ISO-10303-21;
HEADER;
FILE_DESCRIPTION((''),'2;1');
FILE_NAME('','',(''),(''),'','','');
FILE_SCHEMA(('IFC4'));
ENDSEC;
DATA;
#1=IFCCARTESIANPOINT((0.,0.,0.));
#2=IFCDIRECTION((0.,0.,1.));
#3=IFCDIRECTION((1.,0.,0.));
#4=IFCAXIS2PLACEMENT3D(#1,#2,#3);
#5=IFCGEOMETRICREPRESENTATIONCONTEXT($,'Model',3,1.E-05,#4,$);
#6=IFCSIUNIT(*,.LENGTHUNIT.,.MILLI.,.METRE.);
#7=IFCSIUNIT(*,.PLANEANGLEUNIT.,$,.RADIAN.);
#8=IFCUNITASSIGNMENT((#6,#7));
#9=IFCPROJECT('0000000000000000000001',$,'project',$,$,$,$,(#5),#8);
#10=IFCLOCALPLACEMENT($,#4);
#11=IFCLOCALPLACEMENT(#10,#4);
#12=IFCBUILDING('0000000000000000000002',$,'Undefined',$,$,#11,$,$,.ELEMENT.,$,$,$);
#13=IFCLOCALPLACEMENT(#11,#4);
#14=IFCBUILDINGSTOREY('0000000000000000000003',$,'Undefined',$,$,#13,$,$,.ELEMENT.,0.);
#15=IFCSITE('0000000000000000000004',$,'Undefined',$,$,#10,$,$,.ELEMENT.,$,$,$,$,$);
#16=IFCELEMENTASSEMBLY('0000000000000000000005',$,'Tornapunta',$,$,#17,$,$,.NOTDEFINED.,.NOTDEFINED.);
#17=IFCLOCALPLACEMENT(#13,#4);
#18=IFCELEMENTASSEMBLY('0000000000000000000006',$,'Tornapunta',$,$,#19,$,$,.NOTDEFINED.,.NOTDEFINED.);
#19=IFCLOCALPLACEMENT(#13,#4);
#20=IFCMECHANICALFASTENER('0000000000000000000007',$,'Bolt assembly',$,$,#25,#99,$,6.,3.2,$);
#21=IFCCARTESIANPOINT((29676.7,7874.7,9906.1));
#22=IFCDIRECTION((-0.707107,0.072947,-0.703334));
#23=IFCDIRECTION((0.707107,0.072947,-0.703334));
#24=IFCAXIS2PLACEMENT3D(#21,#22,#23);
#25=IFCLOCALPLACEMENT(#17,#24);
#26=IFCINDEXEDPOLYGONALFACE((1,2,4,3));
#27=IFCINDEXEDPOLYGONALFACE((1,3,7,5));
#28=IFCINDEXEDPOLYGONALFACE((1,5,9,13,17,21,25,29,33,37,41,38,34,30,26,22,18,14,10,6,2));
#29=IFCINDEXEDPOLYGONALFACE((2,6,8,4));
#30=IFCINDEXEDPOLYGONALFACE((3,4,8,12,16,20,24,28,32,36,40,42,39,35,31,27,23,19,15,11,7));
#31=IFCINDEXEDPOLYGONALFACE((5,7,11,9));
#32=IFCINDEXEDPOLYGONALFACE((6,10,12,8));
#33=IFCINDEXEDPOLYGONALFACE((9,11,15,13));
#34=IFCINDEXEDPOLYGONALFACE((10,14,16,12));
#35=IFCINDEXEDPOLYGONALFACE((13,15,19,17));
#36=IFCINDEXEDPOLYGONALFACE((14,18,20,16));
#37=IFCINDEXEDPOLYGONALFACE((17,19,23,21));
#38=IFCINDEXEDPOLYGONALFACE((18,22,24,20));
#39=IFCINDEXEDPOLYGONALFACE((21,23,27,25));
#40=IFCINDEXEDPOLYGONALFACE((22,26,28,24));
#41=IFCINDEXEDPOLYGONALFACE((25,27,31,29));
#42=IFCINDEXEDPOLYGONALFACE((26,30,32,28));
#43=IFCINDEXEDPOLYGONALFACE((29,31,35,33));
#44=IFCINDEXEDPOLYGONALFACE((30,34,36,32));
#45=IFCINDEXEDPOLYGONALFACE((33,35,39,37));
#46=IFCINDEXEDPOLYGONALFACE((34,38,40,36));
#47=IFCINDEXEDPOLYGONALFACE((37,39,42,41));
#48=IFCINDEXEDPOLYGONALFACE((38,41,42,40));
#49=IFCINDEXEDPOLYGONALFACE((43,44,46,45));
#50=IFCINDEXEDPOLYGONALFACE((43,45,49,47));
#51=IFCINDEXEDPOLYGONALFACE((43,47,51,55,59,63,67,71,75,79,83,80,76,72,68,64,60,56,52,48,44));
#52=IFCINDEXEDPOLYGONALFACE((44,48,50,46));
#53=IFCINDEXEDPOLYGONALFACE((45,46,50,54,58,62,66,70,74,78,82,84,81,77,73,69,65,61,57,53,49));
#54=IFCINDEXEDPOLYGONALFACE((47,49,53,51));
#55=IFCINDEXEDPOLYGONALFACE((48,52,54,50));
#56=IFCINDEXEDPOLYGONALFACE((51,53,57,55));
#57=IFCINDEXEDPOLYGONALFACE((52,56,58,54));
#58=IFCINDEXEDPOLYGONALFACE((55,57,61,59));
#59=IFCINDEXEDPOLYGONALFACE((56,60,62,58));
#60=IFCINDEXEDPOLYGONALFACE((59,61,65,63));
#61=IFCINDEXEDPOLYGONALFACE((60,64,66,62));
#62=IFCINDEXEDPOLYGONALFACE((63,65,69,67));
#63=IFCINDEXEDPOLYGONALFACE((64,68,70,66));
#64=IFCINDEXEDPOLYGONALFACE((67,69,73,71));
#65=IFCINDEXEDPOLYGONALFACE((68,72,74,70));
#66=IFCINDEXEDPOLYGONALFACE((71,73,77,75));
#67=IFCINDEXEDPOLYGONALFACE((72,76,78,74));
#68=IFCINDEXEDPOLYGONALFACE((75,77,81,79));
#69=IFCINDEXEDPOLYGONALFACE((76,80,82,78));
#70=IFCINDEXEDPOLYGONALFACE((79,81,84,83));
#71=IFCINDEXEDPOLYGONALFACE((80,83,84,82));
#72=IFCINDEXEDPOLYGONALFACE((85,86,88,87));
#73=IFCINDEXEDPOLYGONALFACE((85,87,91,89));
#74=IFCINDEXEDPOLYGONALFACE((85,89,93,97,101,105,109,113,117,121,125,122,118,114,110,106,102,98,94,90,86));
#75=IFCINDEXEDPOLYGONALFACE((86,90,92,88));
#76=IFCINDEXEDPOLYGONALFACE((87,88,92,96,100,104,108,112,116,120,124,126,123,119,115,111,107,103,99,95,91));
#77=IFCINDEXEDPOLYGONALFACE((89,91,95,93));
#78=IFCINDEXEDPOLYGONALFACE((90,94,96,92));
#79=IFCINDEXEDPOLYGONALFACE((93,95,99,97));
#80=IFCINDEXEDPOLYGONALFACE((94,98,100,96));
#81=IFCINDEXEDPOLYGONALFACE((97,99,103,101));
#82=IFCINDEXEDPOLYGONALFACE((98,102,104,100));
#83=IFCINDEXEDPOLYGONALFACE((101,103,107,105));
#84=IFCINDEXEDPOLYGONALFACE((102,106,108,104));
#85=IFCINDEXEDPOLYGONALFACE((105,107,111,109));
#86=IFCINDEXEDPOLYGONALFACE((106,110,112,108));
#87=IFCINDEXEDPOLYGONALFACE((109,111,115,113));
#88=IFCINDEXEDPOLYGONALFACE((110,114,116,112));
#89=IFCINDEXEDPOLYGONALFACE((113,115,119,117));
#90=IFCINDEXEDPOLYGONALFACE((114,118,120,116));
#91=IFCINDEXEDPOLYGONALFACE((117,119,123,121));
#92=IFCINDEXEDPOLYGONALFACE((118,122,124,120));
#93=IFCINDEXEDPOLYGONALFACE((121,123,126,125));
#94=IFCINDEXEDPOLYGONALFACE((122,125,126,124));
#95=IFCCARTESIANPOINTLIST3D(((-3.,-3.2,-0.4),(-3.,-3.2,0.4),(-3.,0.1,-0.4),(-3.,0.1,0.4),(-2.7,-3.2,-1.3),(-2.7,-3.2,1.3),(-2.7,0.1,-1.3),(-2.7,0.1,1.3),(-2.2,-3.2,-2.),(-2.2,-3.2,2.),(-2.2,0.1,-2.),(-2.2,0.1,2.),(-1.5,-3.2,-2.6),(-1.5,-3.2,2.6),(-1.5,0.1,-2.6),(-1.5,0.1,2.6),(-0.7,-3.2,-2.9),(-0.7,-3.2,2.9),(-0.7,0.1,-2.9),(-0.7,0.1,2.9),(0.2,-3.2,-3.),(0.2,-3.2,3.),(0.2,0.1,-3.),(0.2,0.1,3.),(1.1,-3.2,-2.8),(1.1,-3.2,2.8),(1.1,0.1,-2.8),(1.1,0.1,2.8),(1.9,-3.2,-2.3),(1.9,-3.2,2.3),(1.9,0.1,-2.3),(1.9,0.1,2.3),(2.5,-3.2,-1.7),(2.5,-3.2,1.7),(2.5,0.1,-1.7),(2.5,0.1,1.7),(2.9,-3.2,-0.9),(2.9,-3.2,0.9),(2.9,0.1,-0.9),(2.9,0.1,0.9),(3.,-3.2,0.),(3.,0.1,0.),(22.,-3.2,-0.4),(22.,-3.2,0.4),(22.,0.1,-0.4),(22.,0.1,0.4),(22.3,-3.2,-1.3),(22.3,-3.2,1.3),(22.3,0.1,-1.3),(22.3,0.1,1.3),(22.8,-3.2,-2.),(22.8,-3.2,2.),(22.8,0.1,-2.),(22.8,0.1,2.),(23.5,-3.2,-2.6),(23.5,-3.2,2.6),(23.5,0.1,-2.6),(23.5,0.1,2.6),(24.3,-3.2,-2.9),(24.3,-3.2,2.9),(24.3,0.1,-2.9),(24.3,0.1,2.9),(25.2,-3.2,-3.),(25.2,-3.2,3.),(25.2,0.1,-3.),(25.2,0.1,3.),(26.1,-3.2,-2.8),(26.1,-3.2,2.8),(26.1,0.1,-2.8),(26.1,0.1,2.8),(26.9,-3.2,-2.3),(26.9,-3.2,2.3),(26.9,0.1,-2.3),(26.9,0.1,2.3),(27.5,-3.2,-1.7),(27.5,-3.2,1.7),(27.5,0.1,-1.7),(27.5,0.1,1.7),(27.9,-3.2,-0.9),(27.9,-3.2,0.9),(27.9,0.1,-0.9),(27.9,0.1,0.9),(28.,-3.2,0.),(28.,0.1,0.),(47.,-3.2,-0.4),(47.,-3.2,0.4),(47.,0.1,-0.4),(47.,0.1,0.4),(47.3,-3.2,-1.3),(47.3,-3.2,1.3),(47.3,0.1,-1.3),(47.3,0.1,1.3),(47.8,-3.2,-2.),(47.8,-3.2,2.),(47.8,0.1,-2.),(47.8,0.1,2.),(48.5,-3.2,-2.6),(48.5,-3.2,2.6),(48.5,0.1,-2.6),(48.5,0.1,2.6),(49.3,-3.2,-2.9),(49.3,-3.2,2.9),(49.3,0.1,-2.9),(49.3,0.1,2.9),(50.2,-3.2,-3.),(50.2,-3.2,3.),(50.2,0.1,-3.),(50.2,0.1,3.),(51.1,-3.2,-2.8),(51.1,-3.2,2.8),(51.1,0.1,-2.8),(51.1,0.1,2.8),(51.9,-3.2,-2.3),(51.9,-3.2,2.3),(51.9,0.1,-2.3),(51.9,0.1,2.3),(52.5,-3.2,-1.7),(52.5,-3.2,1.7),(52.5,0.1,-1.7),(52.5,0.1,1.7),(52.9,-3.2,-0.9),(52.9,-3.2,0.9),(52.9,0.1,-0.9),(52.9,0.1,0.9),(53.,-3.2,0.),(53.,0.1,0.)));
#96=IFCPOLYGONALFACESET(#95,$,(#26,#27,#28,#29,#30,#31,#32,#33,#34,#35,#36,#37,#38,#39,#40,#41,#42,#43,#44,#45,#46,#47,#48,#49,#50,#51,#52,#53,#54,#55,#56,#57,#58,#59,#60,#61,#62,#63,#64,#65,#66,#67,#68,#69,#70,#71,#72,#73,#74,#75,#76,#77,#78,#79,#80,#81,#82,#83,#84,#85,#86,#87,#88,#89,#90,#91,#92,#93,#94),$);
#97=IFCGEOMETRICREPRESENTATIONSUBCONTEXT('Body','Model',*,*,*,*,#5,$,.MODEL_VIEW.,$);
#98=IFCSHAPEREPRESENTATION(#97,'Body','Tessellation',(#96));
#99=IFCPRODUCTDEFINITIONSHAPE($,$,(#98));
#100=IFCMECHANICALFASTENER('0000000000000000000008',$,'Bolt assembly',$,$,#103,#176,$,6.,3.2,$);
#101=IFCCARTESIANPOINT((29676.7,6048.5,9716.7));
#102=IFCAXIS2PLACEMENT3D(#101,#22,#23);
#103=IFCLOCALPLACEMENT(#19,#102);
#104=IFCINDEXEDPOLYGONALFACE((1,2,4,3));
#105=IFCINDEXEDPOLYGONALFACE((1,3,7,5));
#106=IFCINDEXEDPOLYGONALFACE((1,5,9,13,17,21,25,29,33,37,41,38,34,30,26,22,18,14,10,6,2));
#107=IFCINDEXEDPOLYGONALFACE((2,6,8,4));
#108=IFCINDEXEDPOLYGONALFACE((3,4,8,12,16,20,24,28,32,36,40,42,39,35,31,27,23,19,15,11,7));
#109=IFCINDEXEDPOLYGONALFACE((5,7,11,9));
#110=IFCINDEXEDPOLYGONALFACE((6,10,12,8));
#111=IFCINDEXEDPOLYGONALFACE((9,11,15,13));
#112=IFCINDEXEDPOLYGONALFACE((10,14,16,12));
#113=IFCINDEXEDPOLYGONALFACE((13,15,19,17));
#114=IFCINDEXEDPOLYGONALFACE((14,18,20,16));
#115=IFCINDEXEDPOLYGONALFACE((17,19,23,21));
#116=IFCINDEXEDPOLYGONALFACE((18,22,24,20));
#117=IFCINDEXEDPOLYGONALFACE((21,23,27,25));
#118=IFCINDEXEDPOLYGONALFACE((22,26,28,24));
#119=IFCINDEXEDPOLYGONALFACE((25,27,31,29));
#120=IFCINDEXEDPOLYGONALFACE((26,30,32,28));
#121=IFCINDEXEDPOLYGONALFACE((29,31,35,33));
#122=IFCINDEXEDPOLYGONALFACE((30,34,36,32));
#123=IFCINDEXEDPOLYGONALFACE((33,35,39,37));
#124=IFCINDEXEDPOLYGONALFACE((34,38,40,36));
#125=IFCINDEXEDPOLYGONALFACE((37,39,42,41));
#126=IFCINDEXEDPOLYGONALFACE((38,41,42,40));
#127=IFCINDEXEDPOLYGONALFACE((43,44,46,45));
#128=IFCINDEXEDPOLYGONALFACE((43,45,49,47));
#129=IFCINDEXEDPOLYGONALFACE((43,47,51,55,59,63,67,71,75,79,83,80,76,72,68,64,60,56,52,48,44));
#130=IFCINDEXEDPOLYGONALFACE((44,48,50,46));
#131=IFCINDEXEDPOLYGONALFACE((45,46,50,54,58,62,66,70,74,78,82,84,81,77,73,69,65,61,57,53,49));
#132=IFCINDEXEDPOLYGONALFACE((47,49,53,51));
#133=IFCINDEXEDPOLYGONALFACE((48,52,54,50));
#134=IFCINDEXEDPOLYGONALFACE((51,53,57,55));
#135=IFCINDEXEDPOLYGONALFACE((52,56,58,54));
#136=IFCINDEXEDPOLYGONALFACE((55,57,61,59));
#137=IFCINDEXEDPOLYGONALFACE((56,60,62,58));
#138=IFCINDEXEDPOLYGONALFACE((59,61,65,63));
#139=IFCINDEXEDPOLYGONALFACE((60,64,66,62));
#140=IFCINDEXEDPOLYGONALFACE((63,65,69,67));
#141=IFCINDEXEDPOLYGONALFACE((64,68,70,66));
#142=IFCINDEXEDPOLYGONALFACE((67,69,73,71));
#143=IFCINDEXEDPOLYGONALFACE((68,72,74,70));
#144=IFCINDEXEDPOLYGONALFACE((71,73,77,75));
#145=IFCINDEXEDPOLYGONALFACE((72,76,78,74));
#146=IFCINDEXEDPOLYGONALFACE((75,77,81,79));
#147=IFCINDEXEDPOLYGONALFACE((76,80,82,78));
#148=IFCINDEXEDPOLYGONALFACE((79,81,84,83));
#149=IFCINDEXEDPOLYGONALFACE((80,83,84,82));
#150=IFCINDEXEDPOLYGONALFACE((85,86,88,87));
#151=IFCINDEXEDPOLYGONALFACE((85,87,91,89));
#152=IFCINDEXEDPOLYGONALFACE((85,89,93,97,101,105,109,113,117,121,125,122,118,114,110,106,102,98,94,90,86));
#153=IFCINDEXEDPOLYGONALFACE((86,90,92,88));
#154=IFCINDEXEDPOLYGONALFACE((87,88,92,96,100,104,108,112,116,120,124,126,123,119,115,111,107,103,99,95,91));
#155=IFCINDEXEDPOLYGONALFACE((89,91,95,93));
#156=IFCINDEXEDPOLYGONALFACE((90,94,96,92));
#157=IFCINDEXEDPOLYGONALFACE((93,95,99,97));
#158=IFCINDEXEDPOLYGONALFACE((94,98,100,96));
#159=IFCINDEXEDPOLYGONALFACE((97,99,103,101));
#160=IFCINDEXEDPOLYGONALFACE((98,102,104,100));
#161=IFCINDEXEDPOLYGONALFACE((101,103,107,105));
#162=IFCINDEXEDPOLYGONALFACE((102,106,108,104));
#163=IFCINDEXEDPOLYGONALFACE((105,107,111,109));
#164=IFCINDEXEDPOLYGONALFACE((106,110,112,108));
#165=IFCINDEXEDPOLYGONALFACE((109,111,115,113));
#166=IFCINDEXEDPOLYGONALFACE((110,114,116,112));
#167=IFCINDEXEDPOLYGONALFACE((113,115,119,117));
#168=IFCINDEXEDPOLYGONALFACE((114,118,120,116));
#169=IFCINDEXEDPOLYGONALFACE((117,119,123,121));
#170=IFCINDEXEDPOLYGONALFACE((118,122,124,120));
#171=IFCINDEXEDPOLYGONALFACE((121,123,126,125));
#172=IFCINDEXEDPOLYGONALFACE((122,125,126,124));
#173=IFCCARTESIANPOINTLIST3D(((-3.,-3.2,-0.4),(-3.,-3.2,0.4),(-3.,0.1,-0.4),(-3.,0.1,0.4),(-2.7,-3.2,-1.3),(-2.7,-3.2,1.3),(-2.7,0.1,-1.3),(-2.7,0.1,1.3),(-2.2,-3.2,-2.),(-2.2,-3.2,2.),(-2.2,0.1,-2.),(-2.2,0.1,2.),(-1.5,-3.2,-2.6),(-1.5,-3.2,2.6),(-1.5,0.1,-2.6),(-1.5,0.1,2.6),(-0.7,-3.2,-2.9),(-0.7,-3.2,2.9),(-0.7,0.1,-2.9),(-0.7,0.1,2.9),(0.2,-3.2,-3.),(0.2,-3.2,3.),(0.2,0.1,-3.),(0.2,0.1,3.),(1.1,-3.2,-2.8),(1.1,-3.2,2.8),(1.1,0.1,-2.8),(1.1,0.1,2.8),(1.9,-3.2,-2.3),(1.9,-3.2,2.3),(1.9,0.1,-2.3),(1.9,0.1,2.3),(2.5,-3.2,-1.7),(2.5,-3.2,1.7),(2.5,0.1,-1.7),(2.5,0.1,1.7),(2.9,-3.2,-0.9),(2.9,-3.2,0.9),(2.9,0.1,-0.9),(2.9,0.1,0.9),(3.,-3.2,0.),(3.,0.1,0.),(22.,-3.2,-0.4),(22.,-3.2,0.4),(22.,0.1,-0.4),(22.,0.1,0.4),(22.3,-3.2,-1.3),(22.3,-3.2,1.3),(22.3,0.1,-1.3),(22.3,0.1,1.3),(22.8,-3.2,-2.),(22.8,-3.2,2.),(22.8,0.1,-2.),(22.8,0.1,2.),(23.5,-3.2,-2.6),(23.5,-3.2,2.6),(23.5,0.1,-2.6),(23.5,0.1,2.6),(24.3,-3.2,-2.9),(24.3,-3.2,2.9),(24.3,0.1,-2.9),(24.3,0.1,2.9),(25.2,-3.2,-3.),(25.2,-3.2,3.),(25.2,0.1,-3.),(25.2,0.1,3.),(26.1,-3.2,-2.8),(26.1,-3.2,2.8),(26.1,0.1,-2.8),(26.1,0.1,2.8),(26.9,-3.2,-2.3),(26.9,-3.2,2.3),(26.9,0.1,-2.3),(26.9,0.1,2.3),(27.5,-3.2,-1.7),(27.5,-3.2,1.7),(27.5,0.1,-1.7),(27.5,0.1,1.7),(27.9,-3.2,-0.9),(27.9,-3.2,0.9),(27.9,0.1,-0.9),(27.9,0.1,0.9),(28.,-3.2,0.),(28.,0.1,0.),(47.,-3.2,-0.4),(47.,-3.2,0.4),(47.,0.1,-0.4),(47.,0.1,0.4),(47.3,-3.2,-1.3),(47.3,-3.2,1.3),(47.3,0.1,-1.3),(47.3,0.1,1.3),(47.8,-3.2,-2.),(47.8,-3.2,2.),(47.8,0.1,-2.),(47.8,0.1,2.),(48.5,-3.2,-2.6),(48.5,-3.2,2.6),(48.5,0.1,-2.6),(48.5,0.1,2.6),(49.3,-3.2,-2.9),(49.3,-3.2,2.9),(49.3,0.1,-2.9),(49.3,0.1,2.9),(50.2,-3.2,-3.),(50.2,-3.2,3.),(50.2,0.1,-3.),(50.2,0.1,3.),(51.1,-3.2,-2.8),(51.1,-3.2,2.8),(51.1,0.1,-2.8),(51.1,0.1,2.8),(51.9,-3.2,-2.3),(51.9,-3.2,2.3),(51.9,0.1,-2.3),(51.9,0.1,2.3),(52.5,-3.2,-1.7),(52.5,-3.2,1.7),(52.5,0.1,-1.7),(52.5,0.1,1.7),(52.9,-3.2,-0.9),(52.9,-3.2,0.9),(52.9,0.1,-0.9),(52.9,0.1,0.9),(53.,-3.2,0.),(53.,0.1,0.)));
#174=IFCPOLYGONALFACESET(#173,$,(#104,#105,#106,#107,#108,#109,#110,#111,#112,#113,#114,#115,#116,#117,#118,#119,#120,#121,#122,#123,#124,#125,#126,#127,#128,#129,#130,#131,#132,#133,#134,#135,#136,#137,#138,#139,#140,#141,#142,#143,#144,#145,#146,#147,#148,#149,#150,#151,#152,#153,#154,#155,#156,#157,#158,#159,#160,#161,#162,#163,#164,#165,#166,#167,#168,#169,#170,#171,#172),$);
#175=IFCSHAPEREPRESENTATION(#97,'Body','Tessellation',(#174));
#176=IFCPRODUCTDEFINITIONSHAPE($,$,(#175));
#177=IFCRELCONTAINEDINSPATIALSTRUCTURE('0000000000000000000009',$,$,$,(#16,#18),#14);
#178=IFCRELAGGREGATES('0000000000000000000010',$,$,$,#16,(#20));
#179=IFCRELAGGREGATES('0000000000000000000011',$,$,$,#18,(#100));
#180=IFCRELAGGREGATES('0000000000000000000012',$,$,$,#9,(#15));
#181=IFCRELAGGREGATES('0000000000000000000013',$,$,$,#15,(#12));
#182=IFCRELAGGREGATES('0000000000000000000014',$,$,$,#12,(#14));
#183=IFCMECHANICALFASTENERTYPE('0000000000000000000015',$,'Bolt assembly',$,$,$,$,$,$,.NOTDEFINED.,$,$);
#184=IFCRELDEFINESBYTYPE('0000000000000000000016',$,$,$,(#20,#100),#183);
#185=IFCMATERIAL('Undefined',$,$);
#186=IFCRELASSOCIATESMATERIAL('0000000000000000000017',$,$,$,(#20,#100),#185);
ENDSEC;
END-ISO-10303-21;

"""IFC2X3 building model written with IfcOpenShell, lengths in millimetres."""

from ifc_helpers import new_model, si_unit, frame, origin_with_axes, origin_2d_with_axis, place, context, subcontext, project, spatial, circle, extrude, source, transform, mapped, material, type_object, element, aggregate, save


model = new_model("IFC2X3")

# Units and contexts
model_context = context("Model", 3, precision=1e-05, world=origin_with_axes())
body_context = subcontext(model_context, "Body", "Model", "MODEL_VIEW")
ifc_project = project(units=[si_unit("LENGTHUNIT", "METRE", prefix="MILLI"), si_unit("PLANEANGLEUNIT", "RADIAN")], contexts=[model_context])

# Site, building, storey
site_placement = place(None, origin_with_axes())
site = spatial("IfcSite", under=ifc_project, at=site_placement, Name="Undefined", CompositionType="ELEMENT")
building_placement = place(site_placement, origin_with_axes())
building = spatial("IfcBuilding", under=site, at=building_placement, Name="Undefined", CompositionType="ELEMENT")
storey_placement = place(building_placement, origin_with_axes())
storey = spatial("IfcBuildingStorey", under=building, at=storey_placement, Name="Undefined", CompositionType="ELEMENT", Elevation=0.0)

# Element assemblies
assembly_1_placement = place(storey_placement, origin_with_axes())
assembly_1 = element("IfcElementAssembly", 1, at=assembly_1_placement, inside=storey, Name="Tornapunta", AssemblyPlace="NOTDEFINED", PredefinedType="NOTDEFINED")
assembly_2_placement = place(storey_placement, origin_with_axes())
assembly_2 = element("IfcElementAssembly", 2, at=assembly_2_placement, inside=storey, Name="Tornapunta", AssemblyPlace="NOTDEFINED", PredefinedType="NOTDEFINED")

# Mechanical fasteners
ifc_material_1 = material(Name="Undefined")
mechanical_fastener_type = type_object("IfcMechanicalFastenerType", Name="Bolt assembly")
shared_shape_1 = source(origin_with_axes(), body_context, "Body", "SweptSolid", [
    extrude(circle(Radius=3.0, at=origin_2d_with_axis()), frame((0.0, -3.2, 0.0), z_axis=(0.0, 1.0, 0.0), x_axis=(1.0, 0.0, 0.0)), (0.0, 0.0, 1.0), 3.3),
])
mechanical_fastener_1_placement = place(assembly_1_placement, frame((29676.7, 7874.7, 9906.1), z_axis=(-0.707107, 0.072947, -0.703334), x_axis=(0.707107, 0.072947, -0.703334)))
mechanical_fastener_1 = element("IfcMechanicalFastener", 3, at=mechanical_fastener_1_placement, type_object=mechanical_fastener_type, material=ifc_material_1, Name="Bolt assembly", NominalDiameter=6.0, NominalLength=3.2, context=body_context, shape_type="MappedRepresentation", body=[
    mapped(shared_shape_1, transform((0.0, 0.0, 0.0))),
    mapped(shared_shape_1, transform((25.0, 0.0, 0.0))),
    mapped(shared_shape_1, transform((50.0, 0.0, 0.0))),
])
aggregate(assembly_1, [mechanical_fastener_1])
mechanical_fastener_2_placement = place(assembly_2_placement, frame((29676.7, 6048.5, 9716.7), z_axis=(-0.707107, 0.072947, -0.703334), x_axis=(0.707107, 0.072947, -0.703334)))
mechanical_fastener_2 = element("IfcMechanicalFastener", 4, at=mechanical_fastener_2_placement, type_object=mechanical_fastener_type, material=ifc_material_1, Name="Bolt assembly", NominalDiameter=6.0, NominalLength=3.2, context=body_context, shape_type="MappedRepresentation", body=[
    mapped(shared_shape_1, transform((0.0, 0.0, 0.0))),
    mapped(shared_shape_1, transform((25.0, 0.0, 0.0))),
    mapped(shared_shape_1, transform((50.0, 0.0, 0.0))),
])
aggregate(assembly_2, [mechanical_fastener_2])

save(model, "model.ifc")
